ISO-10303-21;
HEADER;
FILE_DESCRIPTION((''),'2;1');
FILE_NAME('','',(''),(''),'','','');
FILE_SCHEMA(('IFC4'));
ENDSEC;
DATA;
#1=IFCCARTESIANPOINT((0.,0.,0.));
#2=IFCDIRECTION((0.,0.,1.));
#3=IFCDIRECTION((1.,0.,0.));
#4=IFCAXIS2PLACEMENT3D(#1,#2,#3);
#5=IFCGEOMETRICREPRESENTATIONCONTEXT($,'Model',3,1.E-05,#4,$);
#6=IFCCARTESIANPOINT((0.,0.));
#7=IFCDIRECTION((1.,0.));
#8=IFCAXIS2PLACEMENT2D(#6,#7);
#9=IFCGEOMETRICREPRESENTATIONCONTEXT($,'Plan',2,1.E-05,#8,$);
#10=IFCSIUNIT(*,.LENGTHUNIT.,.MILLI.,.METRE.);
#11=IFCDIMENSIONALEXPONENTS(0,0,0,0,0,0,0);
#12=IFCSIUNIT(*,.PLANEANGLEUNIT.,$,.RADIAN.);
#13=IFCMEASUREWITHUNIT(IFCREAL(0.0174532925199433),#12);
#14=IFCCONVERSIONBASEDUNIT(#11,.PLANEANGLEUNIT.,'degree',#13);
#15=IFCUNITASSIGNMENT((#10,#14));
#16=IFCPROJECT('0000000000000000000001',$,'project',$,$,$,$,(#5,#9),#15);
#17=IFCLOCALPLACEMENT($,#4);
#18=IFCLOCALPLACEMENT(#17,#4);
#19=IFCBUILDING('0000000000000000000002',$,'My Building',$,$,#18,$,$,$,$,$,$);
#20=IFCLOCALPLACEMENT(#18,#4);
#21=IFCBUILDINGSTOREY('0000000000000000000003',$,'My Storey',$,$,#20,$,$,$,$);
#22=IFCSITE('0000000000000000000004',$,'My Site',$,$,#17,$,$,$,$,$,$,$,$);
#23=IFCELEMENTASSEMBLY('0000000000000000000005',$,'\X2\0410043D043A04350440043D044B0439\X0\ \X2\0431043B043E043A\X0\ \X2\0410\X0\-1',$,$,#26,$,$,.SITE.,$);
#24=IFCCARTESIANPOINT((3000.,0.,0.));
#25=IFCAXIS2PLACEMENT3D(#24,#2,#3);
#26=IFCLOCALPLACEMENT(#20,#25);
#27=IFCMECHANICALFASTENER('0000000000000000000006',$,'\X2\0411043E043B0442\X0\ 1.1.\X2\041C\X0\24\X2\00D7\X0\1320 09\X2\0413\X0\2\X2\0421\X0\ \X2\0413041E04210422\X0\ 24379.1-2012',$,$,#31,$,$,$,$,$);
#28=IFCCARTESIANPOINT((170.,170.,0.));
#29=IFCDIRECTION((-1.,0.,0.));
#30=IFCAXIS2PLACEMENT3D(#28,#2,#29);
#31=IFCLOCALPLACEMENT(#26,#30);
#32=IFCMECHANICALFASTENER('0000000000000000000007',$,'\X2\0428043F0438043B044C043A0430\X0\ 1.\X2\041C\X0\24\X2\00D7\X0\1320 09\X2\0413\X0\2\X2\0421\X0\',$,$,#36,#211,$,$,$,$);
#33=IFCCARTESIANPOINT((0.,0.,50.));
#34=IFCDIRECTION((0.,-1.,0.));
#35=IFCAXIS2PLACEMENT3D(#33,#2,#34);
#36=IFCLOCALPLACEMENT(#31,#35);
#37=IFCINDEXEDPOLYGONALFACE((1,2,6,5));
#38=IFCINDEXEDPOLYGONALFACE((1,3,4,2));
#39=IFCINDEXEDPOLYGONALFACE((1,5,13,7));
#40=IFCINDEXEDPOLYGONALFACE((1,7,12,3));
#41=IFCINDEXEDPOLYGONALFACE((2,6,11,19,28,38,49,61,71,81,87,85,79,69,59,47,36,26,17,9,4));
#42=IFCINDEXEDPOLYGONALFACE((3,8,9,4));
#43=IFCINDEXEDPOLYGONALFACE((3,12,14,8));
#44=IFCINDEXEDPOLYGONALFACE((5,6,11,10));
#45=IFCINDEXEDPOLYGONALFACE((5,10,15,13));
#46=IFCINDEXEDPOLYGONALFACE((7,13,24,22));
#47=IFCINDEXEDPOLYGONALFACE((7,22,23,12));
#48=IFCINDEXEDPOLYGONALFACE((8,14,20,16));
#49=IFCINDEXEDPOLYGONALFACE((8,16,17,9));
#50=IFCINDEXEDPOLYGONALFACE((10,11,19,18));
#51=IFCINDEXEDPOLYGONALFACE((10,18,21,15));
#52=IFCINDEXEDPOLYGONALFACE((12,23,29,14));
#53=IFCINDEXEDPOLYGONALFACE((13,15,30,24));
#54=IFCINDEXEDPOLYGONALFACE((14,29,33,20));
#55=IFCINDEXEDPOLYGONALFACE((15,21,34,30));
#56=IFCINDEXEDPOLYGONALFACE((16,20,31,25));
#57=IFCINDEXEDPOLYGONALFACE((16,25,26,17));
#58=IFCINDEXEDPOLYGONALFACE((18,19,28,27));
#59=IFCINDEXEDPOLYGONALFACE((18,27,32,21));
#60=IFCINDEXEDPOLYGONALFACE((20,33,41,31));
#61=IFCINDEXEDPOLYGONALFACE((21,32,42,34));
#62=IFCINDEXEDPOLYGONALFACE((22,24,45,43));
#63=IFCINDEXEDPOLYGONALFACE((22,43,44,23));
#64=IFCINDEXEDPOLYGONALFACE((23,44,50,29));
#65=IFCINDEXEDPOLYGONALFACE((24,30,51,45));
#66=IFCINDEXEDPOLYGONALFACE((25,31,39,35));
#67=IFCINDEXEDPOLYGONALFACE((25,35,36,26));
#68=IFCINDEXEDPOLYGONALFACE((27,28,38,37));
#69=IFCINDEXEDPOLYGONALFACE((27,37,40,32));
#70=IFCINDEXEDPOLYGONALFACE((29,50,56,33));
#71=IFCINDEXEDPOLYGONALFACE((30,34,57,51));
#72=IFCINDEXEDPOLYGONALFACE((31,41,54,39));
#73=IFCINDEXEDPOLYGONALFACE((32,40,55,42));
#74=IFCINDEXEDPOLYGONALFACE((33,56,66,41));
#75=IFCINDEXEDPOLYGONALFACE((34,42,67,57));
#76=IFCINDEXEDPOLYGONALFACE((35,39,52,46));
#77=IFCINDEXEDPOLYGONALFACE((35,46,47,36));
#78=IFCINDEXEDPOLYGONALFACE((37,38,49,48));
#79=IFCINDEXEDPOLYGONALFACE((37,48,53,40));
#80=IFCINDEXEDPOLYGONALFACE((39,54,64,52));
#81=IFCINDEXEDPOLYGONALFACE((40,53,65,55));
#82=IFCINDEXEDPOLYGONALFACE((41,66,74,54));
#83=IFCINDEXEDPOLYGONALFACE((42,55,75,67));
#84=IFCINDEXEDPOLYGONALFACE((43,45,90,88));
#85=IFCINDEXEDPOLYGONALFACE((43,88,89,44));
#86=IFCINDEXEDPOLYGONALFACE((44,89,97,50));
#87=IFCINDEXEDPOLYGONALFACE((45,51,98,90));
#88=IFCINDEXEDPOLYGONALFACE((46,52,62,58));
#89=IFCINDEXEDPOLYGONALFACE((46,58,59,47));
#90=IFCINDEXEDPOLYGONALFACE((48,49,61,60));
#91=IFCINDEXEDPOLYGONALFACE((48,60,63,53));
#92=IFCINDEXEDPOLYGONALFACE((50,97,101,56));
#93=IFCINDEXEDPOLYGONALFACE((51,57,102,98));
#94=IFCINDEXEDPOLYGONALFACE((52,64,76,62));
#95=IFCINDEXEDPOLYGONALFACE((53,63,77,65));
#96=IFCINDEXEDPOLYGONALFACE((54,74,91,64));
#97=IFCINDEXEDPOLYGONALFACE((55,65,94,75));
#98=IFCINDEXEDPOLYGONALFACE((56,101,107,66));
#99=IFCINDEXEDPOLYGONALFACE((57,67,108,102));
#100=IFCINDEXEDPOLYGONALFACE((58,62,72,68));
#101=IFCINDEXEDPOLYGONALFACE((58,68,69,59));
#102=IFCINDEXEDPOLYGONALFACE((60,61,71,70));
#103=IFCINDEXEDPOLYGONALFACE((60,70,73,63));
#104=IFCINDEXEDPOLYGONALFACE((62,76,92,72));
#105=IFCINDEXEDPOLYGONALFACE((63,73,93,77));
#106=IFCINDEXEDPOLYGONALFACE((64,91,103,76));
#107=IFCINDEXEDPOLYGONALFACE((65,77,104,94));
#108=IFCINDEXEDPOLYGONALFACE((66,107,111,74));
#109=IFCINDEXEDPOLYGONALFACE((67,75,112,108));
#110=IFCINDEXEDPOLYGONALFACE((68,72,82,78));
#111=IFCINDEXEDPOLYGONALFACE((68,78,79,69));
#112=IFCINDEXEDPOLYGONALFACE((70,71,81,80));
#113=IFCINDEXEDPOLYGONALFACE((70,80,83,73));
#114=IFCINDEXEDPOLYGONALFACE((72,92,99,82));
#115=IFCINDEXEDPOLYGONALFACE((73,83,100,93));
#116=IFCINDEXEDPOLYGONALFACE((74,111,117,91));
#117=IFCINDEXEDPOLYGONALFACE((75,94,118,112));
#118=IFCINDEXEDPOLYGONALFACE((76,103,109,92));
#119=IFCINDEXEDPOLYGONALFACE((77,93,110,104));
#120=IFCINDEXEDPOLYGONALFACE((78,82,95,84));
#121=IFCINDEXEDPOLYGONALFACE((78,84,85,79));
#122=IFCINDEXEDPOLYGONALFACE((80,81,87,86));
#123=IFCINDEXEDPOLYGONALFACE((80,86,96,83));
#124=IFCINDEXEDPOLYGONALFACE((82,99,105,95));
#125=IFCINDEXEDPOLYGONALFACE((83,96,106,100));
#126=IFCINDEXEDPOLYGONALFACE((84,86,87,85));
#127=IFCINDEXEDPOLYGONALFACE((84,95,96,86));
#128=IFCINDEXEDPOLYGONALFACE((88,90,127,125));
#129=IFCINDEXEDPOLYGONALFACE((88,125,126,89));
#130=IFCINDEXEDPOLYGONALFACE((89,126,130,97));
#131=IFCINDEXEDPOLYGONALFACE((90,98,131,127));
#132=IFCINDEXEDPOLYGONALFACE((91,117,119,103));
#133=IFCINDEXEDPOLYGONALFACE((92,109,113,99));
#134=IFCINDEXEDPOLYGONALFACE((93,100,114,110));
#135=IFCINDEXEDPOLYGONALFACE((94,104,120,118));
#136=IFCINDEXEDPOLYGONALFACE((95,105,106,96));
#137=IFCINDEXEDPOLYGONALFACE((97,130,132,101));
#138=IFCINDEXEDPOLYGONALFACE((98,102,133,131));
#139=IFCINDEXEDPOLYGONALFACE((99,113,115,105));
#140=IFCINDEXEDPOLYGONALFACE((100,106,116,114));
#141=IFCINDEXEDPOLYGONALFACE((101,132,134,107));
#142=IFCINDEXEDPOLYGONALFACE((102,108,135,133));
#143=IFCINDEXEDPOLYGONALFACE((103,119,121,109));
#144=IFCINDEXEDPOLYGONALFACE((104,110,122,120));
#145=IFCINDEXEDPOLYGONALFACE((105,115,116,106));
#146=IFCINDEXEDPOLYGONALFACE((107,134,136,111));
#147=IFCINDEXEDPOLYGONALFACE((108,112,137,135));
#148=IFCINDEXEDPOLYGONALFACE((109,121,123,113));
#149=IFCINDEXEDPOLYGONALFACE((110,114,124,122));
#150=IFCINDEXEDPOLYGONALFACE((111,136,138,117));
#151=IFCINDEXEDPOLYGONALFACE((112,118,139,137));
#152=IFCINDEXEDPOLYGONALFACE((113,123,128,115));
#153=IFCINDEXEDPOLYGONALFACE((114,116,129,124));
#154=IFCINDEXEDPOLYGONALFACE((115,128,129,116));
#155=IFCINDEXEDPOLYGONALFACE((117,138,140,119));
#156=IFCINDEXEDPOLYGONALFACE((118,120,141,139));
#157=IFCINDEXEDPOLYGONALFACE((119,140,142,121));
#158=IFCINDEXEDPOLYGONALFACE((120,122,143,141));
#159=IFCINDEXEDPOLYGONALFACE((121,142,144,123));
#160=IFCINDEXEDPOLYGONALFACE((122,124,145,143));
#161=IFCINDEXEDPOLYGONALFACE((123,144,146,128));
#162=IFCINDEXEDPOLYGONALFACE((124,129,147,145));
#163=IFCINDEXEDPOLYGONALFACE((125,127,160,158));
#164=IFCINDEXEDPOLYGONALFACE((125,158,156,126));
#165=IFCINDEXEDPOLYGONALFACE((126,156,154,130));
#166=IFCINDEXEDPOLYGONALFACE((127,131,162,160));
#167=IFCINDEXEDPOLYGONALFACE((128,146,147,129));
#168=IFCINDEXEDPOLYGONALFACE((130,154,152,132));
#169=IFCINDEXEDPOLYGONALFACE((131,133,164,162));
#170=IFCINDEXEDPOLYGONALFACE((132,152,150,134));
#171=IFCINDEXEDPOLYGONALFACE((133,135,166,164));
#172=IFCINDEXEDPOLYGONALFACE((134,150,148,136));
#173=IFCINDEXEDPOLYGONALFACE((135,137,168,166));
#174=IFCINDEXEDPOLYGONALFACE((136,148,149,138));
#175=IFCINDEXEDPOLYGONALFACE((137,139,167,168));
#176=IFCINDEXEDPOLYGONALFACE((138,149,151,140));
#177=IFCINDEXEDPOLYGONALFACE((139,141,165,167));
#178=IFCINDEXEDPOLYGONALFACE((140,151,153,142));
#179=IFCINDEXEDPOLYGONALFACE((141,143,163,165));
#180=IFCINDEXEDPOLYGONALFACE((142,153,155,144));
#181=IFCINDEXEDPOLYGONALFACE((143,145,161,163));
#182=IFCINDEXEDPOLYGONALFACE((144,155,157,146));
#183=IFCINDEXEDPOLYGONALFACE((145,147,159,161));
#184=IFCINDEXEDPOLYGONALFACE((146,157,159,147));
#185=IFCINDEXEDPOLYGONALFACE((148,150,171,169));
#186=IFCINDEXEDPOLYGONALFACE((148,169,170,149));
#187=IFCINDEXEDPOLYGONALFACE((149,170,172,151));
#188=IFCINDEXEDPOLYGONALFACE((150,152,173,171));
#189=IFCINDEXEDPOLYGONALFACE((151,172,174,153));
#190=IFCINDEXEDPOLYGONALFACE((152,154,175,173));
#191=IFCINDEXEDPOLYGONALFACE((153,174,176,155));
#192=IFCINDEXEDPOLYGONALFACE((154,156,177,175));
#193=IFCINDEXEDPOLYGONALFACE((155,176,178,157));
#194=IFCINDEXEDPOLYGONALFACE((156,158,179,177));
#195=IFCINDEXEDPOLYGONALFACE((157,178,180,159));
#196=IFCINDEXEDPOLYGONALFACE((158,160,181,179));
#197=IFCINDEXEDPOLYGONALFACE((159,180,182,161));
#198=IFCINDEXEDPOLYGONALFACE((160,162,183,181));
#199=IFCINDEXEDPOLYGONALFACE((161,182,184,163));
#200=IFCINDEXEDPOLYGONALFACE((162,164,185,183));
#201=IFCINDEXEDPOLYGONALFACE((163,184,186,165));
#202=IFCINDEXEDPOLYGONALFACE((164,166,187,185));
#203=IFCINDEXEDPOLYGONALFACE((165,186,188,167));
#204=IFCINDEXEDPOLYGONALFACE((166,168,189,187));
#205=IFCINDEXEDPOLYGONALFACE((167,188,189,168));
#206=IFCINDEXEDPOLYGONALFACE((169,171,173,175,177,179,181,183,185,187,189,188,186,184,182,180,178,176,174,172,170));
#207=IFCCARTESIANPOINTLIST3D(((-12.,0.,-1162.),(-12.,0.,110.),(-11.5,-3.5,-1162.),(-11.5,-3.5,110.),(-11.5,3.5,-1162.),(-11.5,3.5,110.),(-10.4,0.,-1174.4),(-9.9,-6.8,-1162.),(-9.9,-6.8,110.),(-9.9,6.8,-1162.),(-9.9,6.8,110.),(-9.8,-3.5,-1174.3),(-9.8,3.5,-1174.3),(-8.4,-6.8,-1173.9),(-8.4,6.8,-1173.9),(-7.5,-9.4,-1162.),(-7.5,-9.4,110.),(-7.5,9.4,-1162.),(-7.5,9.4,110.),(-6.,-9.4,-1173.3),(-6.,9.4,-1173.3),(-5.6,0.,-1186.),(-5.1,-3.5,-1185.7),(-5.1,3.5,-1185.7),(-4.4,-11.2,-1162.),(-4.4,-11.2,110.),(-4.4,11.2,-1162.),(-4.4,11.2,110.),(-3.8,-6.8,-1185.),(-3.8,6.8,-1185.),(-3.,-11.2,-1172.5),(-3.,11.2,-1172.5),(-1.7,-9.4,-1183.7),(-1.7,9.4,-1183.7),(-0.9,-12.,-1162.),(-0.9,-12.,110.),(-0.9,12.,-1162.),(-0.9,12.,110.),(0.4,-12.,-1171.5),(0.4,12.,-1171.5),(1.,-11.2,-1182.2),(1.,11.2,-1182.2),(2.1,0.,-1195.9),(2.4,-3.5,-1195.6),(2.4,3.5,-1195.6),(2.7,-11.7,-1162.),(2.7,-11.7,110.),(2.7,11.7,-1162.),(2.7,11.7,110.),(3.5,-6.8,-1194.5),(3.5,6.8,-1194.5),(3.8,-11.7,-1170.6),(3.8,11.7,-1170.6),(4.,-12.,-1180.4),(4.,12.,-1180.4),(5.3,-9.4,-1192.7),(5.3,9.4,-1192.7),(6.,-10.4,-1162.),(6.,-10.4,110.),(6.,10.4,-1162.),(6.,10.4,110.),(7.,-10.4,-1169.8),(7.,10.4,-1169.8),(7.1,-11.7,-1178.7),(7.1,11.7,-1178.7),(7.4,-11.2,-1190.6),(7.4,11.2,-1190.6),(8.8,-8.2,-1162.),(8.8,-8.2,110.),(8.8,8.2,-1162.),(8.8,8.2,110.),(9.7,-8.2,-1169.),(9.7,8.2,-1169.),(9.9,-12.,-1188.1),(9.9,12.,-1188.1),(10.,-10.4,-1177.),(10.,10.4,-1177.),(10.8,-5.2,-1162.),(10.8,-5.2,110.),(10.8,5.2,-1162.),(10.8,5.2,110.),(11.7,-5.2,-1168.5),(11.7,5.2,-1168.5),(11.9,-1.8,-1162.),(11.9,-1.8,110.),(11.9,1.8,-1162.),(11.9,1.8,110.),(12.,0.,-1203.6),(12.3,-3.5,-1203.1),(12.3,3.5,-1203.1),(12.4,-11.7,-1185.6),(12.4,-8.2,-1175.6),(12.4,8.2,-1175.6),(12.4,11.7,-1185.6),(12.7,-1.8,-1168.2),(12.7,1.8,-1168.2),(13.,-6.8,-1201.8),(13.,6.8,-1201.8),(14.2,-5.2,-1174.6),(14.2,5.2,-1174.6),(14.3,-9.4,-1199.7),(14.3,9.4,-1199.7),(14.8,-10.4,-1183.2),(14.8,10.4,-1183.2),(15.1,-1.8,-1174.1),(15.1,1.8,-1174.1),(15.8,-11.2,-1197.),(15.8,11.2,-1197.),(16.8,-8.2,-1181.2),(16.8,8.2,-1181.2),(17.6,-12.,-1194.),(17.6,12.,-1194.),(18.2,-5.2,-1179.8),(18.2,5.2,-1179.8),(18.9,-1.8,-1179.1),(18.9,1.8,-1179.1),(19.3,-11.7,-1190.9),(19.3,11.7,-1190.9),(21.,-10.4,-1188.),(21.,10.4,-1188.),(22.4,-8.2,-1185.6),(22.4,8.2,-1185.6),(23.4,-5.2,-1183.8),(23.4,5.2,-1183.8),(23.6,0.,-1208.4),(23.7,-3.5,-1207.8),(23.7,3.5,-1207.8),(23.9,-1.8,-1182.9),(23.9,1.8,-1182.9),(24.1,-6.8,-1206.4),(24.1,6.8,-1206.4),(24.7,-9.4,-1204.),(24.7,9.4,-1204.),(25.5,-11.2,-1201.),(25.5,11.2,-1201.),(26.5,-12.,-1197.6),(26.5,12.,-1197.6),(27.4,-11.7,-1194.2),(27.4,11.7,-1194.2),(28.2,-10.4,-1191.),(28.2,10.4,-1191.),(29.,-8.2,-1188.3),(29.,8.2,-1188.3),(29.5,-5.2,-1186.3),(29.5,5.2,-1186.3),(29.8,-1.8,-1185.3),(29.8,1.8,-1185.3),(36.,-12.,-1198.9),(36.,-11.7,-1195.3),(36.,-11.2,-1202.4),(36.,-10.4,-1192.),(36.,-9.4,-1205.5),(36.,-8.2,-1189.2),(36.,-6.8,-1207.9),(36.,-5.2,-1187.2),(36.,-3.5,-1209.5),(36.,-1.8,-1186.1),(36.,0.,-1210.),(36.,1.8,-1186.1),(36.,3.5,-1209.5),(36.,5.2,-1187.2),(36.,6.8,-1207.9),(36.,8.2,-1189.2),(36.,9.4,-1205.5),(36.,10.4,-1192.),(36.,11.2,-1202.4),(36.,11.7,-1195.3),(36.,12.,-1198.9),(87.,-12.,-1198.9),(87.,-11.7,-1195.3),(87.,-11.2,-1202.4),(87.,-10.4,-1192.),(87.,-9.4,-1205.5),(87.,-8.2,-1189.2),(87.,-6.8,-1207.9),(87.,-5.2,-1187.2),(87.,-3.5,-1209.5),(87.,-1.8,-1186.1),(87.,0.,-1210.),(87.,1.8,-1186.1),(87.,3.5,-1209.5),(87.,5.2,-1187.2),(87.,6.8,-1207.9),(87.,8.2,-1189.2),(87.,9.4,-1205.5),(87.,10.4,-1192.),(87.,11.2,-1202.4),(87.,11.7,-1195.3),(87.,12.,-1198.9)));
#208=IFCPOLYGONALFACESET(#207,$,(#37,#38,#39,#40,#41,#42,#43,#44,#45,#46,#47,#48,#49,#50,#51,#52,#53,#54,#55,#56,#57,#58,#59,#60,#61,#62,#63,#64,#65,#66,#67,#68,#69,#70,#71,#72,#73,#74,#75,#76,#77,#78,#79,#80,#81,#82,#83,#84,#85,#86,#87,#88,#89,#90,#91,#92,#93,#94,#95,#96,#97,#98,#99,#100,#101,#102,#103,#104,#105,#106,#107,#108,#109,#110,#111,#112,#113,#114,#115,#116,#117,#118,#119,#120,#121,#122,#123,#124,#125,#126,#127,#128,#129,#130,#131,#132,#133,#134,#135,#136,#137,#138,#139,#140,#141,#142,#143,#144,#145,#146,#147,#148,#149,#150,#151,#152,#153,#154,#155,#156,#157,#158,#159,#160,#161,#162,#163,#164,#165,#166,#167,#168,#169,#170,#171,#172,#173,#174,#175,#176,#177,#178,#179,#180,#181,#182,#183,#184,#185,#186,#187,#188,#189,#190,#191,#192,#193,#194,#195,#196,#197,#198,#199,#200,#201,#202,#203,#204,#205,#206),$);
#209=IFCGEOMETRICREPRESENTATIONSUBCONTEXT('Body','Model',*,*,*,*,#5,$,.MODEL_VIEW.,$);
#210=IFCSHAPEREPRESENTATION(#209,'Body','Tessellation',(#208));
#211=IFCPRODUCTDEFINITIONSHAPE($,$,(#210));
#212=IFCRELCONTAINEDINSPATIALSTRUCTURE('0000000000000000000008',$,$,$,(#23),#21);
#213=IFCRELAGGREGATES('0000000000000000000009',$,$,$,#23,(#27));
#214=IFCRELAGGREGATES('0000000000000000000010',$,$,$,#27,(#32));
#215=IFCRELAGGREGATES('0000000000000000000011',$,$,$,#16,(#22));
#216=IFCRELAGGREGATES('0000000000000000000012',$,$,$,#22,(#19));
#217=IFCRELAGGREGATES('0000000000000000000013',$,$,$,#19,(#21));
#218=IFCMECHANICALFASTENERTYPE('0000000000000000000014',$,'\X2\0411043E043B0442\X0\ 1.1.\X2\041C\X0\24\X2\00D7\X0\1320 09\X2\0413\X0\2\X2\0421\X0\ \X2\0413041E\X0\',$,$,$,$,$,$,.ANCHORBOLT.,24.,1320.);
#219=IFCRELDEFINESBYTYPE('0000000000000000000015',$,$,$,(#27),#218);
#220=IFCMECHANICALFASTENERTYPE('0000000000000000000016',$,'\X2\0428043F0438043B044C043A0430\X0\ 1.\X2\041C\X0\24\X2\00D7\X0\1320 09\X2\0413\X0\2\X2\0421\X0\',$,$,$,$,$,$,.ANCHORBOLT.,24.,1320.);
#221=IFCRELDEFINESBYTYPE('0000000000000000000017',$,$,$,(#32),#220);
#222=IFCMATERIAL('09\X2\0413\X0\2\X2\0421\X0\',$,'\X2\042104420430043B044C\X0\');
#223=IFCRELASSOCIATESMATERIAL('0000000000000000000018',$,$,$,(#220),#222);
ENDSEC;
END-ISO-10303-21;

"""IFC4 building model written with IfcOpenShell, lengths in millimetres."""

from ifc_helpers import new_model, entity, si_unit, converted_unit, frame, origin_with_axes, origin_2d_with_axis, place, context, subcontext, project, spatial, source, transform, mapped, material, type_object, type_shapes, element, aggregate, save


model = new_model("IFC4")

# Units and contexts
model_context = context("Model", 3, precision=1e-05, world=origin_with_axes())
plan_context = context("Plan", 2, precision=1e-05, world=origin_2d_with_axis())
body_context = subcontext(model_context, "Body", "Model", "MODEL_VIEW")
ifc_project = project(units=[si_unit("LENGTHUNIT", "METRE", prefix="MILLI"), converted_unit("PLANEANGLEUNIT", "degree", entity("IfcReal", 0.0174532925199433), si_unit("PLANEANGLEUNIT", "RADIAN"), dimensions=[0, 0, 0, 0, 0, 0, 0])], contexts=[model_context, plan_context])

# Site, building, storey
site_placement = place(None, origin_with_axes())
site = spatial("IfcSite", under=ifc_project, at=site_placement, Name="My Site")
building_placement = place(site_placement, origin_with_axes())
building = spatial("IfcBuilding", under=site, at=building_placement, Name="My Building")
storey_placement = place(building_placement, origin_with_axes())
storey = spatial("IfcBuildingStorey", under=building, at=storey_placement, Name="My Storey")

# Element assembly, mechanical fasteners
assembly_placement = place(storey_placement, frame((3000.0, 0.0, 0.0), z_axis=(0.0, 0.0, 1.0), x_axis=(1.0, 0.0, 0.0)))
assembly = element("IfcElementAssembly", 1, at=assembly_placement, inside=storey, Name="Анкерный блок А-1", AssemblyPlace="SITE")
mechanical_fastener_type_1 = type_object("IfcMechanicalFastenerType", Name="Болт 1.1.М24×1320 09Г2С ГО", NominalDiameter=24.0, NominalLength=1320.0, PredefinedType="ANCHORBOLT")
ifc_material_1 = material(Name="09Г2С", Category="Сталь")
mechanical_fastener_type_2 = type_object("IfcMechanicalFastenerType", Name="Шпилька 1.М24×1320 09Г2С", NominalDiameter=24.0, NominalLength=1320.0, PredefinedType="ANCHORBOLT", material=ifc_material_1)
shared_shape_1 = source(frame((0.0, 0.0, 110.0), z_axis=(0.0, 0.0, 1.0), x_axis=(1.0, 0.0, 0.0)), body_context, "Body", "AdvancedSweptSolid", [
    entity("IfcSweptDiskSolid", entity("IfcIndexedPolyCurve", entity("IfcCartesianPointList3D", [[0.0, 0.0, 0.0], [0.0, 0.0, -1272.0], [10.5, 0.0, -1297.5], [36.0, 0.0, -1308.0], [87.0, 0.0, -1308.0]]), [entity("IfcLineIndex", [1, 2]), entity("IfcArcIndex", [2, 3, 4]), entity("IfcLineIndex", [4, 5])]), 12.0),
])
type_shapes(mechanical_fastener_type_2, [shared_shape_1])
mechanical_fastener_1_placement = place(assembly_placement, frame((170.0, 170.0, 0.0), z_axis=(0.0, 0.0, 1.0), x_axis=(-1.0, 0.0, 0.0)))
mechanical_fastener_1 = element("IfcMechanicalFastener", 2, at=mechanical_fastener_1_placement, type_object=mechanical_fastener_type_1, Name="Болт 1.1.М24×1320 09Г2С ГОСТ 24379.1-2012")
aggregate(assembly, [mechanical_fastener_1])
mechanical_fastener_2_placement = place(mechanical_fastener_1_placement, frame((0.0, 0.0, 50.0), z_axis=(0.0, 0.0, 1.0), x_axis=(0.0, -1.0, 0.0)))
mechanical_fastener_2 = element("IfcMechanicalFastener", 3, at=mechanical_fastener_2_placement, type_object=mechanical_fastener_type_2, Name="Шпилька 1.М24×1320 09Г2С", context=body_context, shape_type="MappedRepresentation", body=[
    mapped(shared_shape_1, transform((0.0, 0.0, 0.0), x_axis=(1.0, 0.0, 0.0), y_axis=(0.0, 1.0, 0.0), z_axis=(0.0, 0.0, 1.0), scale=1.0)),
])
aggregate(mechanical_fastener_1, [mechanical_fastener_2])

save(model, "model.ifc")
